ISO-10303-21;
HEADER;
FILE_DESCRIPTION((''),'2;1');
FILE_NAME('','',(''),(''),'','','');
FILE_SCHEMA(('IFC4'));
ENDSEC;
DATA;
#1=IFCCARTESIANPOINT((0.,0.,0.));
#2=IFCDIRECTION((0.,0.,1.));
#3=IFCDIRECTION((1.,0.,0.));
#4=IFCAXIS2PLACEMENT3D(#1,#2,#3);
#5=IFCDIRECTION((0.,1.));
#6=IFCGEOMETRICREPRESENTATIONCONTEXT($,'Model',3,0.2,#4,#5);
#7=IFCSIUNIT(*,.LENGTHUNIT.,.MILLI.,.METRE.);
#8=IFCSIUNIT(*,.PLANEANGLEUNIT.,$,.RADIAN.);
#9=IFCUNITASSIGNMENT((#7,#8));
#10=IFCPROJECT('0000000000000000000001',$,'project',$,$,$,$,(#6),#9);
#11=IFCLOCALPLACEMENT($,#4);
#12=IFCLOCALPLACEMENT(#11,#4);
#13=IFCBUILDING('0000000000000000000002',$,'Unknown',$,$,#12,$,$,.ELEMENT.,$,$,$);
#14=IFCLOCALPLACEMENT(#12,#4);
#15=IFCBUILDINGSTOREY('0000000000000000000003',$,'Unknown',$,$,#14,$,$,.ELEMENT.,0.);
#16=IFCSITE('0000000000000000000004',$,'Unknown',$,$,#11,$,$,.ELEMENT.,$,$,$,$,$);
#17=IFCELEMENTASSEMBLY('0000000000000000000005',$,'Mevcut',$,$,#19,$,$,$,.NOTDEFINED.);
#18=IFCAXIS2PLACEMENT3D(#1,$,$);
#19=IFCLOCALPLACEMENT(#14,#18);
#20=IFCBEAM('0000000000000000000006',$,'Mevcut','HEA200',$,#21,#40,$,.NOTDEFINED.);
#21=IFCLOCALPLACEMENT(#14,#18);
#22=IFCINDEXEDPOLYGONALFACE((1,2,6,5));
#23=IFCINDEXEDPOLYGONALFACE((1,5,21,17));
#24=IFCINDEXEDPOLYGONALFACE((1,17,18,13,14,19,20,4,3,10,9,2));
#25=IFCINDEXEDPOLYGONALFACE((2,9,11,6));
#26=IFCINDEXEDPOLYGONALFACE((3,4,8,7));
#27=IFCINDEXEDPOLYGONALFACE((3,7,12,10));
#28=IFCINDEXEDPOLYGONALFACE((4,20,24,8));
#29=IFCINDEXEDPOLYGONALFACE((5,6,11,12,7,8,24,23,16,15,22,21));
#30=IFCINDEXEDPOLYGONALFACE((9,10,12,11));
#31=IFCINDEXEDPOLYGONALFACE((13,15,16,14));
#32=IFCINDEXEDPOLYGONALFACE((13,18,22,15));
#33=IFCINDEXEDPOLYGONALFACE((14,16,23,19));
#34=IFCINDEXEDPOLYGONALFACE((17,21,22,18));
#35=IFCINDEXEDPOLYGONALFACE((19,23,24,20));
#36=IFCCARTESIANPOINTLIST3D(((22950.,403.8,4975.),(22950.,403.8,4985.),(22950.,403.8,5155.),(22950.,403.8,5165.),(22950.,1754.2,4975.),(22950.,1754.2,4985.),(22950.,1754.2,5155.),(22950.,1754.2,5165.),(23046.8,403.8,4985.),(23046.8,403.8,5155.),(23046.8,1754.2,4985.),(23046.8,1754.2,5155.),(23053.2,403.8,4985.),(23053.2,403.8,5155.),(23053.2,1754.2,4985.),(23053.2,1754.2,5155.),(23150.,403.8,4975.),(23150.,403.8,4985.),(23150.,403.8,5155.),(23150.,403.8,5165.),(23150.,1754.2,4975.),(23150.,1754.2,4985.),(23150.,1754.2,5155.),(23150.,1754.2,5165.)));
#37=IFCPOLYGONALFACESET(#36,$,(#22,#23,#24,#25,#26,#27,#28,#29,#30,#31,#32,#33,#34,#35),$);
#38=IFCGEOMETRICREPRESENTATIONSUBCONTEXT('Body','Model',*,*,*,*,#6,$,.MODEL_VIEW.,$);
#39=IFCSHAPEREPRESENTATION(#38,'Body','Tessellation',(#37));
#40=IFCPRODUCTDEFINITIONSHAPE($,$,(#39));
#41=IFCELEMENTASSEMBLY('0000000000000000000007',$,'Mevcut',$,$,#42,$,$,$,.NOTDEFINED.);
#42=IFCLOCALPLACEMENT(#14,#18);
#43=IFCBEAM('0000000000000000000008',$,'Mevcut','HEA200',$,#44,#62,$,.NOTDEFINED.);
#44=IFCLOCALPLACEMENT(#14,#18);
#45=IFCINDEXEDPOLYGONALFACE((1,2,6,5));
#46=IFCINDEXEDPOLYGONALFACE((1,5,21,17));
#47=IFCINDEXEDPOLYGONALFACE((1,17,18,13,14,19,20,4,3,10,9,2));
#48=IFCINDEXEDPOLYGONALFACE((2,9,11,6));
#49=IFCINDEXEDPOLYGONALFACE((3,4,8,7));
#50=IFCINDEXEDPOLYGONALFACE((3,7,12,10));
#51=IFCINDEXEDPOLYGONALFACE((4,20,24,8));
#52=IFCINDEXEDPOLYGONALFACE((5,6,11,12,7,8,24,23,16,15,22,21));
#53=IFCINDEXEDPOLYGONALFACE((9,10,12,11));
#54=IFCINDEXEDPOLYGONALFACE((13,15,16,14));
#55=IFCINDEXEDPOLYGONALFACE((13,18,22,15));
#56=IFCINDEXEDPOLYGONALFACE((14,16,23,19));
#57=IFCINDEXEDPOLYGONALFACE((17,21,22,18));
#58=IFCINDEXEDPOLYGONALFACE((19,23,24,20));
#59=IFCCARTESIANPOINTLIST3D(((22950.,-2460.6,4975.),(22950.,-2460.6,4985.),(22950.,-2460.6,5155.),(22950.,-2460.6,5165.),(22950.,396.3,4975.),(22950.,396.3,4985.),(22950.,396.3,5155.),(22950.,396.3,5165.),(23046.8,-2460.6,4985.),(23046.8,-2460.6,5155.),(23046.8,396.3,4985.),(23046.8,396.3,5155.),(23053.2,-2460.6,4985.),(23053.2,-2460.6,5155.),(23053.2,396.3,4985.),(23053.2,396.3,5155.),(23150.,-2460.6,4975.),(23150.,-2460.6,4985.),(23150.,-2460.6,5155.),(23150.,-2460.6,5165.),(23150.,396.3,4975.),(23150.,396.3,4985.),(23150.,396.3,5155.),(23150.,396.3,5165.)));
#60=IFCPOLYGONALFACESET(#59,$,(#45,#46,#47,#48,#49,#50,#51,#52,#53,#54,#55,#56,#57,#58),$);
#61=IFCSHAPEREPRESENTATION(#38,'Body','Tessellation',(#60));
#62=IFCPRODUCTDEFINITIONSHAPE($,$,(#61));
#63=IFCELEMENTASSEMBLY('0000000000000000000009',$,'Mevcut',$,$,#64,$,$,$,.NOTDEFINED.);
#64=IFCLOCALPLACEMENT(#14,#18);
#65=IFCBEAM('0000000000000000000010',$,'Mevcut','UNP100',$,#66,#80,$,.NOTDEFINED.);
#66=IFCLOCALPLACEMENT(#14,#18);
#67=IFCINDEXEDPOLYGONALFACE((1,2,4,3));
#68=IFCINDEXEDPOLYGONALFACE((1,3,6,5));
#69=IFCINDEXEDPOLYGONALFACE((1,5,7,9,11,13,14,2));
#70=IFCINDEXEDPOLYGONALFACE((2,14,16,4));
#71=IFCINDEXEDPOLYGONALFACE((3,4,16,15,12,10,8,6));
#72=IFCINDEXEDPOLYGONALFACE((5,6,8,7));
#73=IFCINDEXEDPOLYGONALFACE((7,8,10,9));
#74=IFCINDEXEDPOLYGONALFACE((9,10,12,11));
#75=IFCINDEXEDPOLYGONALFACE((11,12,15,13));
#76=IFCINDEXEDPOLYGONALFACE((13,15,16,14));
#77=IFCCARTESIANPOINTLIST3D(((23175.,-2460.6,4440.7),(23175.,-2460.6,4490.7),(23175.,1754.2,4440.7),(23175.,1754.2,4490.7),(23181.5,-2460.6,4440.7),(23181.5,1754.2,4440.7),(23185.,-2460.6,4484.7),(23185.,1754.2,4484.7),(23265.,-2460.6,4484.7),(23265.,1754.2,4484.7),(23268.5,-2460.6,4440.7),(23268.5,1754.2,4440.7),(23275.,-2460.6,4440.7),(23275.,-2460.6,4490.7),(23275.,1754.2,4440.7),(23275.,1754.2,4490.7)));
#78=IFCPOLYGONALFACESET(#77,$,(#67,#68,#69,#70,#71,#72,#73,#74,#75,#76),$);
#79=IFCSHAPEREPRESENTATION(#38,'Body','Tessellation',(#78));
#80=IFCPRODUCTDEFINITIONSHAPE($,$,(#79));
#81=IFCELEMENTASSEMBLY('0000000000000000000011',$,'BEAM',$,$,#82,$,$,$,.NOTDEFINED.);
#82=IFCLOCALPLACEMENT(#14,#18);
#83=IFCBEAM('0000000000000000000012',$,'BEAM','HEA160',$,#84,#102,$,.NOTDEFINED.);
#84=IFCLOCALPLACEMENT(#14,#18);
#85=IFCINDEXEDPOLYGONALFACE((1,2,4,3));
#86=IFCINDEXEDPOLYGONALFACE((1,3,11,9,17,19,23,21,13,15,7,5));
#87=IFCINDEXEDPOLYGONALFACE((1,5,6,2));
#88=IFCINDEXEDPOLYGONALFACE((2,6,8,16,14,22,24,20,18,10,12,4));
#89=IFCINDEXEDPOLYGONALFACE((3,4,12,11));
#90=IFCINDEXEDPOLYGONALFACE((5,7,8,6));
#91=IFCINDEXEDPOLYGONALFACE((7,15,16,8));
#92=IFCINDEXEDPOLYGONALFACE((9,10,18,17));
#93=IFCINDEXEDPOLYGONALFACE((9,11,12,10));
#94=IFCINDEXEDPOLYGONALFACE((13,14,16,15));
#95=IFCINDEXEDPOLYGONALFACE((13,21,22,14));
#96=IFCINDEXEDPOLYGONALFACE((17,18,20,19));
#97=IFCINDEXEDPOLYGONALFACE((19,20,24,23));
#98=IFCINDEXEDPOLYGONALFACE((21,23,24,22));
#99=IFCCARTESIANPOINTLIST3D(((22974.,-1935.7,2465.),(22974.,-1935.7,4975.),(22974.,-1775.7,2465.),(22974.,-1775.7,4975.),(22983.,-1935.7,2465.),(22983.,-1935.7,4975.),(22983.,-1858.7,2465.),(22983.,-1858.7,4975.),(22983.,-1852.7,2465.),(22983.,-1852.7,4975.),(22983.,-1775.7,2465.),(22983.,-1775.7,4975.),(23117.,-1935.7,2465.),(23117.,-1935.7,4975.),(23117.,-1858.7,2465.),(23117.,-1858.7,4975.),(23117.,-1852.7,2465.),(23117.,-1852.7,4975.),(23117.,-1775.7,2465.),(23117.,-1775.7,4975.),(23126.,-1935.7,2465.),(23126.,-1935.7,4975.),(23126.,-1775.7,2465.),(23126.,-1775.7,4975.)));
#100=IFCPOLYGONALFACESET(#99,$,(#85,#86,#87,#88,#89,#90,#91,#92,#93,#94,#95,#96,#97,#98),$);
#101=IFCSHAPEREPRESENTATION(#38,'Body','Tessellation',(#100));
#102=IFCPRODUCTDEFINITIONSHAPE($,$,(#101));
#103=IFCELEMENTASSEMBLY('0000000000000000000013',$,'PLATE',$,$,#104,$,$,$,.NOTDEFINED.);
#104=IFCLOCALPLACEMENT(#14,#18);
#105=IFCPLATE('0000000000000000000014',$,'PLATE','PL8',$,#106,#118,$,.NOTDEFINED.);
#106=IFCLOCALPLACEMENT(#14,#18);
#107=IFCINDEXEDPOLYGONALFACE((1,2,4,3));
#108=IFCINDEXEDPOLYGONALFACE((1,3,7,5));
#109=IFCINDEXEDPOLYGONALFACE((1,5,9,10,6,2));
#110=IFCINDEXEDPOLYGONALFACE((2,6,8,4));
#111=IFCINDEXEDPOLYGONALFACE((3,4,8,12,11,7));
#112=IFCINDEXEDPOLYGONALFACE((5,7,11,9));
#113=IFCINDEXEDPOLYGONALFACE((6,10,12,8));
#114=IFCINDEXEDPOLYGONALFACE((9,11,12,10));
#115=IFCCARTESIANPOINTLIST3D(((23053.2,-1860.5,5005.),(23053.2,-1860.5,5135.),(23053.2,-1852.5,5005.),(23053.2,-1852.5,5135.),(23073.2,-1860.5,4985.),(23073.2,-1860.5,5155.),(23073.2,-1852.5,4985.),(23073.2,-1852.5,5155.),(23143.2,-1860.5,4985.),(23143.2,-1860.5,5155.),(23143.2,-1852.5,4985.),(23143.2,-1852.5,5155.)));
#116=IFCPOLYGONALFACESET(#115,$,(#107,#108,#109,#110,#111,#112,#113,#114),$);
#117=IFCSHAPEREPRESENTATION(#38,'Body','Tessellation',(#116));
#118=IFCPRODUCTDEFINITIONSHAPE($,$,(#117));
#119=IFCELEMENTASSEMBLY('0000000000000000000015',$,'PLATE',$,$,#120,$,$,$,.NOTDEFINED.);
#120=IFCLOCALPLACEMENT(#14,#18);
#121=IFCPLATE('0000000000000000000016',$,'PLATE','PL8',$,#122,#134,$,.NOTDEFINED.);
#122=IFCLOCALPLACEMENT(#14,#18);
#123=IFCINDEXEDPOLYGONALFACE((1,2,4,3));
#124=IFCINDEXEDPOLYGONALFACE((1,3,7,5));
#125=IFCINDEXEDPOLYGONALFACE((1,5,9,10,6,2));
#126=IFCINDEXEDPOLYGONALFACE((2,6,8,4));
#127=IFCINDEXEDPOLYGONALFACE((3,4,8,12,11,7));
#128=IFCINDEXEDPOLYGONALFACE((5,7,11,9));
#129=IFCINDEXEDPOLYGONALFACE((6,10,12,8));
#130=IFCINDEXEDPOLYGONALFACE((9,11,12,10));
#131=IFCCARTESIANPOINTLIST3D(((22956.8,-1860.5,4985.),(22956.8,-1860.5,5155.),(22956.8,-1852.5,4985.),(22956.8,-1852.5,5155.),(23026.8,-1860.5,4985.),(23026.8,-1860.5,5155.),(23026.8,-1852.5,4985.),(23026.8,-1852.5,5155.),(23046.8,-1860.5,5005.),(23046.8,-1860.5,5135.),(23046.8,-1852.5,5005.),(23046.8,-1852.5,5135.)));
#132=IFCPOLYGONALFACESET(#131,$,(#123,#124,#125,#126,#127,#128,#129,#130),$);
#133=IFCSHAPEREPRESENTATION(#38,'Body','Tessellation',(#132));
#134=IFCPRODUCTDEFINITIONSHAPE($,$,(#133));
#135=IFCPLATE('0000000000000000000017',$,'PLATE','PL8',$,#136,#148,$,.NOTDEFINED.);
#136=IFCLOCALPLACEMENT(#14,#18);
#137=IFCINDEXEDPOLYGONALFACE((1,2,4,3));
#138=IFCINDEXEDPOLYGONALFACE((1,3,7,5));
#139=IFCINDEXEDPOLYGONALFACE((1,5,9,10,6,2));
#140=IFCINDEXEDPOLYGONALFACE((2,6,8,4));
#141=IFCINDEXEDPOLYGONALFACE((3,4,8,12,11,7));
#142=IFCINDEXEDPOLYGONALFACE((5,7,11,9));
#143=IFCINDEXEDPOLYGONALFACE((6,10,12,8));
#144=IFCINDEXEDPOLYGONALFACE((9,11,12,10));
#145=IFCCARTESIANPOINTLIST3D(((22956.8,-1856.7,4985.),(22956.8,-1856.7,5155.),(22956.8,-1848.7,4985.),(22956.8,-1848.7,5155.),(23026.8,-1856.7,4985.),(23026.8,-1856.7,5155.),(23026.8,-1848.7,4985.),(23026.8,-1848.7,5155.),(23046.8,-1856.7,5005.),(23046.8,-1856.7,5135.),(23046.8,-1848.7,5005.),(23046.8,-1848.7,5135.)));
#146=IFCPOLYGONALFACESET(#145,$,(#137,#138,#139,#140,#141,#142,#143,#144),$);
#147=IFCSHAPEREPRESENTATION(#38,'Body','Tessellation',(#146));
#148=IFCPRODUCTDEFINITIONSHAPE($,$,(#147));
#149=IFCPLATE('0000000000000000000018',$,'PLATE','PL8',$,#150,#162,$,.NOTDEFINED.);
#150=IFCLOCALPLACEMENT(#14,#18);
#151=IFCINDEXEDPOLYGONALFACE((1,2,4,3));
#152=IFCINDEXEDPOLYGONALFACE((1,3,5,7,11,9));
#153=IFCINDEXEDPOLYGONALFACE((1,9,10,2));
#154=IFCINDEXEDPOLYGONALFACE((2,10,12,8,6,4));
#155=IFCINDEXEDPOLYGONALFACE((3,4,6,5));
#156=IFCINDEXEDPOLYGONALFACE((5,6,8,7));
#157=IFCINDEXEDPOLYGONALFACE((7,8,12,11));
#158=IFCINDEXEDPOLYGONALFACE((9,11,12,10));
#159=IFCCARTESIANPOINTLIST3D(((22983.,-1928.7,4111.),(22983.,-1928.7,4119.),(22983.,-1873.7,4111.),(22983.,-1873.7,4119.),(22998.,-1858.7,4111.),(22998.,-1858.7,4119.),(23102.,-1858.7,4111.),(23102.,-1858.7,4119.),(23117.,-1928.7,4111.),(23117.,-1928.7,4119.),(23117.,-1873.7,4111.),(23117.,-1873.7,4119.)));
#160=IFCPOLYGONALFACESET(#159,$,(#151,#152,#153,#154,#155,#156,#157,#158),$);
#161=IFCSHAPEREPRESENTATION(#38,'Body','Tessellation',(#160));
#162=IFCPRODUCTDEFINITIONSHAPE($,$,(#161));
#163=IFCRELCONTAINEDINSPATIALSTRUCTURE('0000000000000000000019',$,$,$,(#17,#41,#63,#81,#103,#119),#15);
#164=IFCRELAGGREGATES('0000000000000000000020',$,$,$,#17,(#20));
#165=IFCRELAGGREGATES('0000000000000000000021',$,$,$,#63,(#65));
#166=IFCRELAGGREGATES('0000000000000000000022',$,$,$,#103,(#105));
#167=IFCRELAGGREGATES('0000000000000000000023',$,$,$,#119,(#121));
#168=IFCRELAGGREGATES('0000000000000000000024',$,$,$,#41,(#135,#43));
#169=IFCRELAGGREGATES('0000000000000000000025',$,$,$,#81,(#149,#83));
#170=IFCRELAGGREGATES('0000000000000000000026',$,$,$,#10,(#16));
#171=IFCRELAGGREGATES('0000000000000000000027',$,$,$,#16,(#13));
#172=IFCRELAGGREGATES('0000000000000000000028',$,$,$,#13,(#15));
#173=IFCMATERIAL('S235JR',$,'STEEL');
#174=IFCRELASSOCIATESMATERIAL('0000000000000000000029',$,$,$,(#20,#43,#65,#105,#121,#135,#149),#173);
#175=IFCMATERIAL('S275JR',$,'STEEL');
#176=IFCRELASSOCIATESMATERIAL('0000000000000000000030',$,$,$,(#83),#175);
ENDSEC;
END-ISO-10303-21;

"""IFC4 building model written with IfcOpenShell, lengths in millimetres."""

from ifc_helpers import new_model, si_unit, direction, frame, origin_with_axes, place, context, subcontext, project, spatial, line, indexed_curve, outline, extrude, material, element, aggregate, save


model = new_model("IFC4")

# Units and contexts
model_context = context("Model", 3, precision=0.2, world=origin_with_axes(), true_north=direction((0.0, 1.0)))
body_context = subcontext(model_context, "Body", "Model", "MODEL_VIEW")
ifc_project = project(units=[si_unit("LENGTHUNIT", "METRE", prefix="MILLI"), si_unit("PLANEANGLEUNIT", "RADIAN")], contexts=[model_context])

# Site, building, storey
site_placement = place(None, origin_with_axes())
site = spatial("IfcSite", under=ifc_project, at=site_placement, Name="Unknown", CompositionType="ELEMENT")
building_placement = place(site_placement, origin_with_axes())
building = spatial("IfcBuilding", under=site, at=building_placement, Name="Unknown", CompositionType="ELEMENT")
storey_placement = place(building_placement, origin_with_axes())
storey = spatial("IfcBuildingStorey", under=building, at=storey_placement, Name="Unknown", CompositionType="ELEMENT", Elevation=0.0)

# Element assemblies, beams
assembly_1_placement = place(storey_placement, frame((23050.0, 1754.2, 5070.0), z_axis=(-1.0, 0.0, 0.0), x_axis=(0.0, -1.0, 0.0)))
assembly_1 = element("IfcElementAssembly", 1, at=assembly_1_placement, inside=storey, Name="Mevcut", PredefinedType="NOTDEFINED")
ifc_material_1 = material(Name="S235JR", Category="STEEL")
beam_1_placement = place(assembly_1_placement, origin_with_axes())
beam_1 = element("IfcBeam", 2, at=beam_1_placement, material=ifc_material_1, Name="Mevcut", Description="HEA200", PredefinedType="NOTDEFINED", context=body_context, shape_type="SolidModel", body=[
    extrude(outline(indexed_curve([(-100.0, -95.0), (100.0, -95.0), (100.0, -85.0), (3.2, -85.0), (3.2, 85.0), (100.0, 85.0), (100.0, 95.0), (-100.0, 95.0), (-100.0, 85.0), (-3.2, 85.0), (-3.2, -85.0), (-100.0, -85.0)], segments=[line(1, 2, 3, 4, 5, 6, 7, 8, 9, 10, 11, 12, 1)])), frame((0.0, 0.0, 0.0), z_axis=(-1.0, 0.0, 0.0), x_axis=(0.0, 0.0, 1.0)), (0.0, 0.0, -1.0), 1350.4),
])
aggregate(assembly_1, [beam_1])
assembly_2_placement = place(storey_placement, frame((23050.0, 396.3, 5070.0), z_axis=(-1.0, 0.0, 0.0), x_axis=(0.0, -1.0, 0.0)))
assembly_2 = element("IfcElementAssembly", 3, at=assembly_2_placement, inside=storey, Name="Mevcut", PredefinedType="NOTDEFINED")
beam_2_placement = place(assembly_2_placement, origin_with_axes())
beam_2 = element("IfcBeam", 4, at=beam_2_placement, material=ifc_material_1, Name="Mevcut", Description="HEA200", PredefinedType="NOTDEFINED", context=body_context, shape_type="SolidModel", body=[
    extrude(outline(indexed_curve([(-100.0, -95.0), (100.0, -95.0), (100.0, -85.0), (3.2, -85.0), (3.2, 85.0), (100.0, 85.0), (100.0, 95.0), (-100.0, 95.0), (-100.0, 85.0), (-3.2, 85.0), (-3.2, -85.0), (-100.0, -85.0)], segments=[line(1, 2, 3, 4, 5, 6, 7, 8, 9, 10, 11, 12, 1)])), frame((0.0, 0.0, 0.0), z_axis=(-1.0, 0.0, 0.0), x_axis=(0.0, 0.0, 1.0)), (0.0, 0.0, -1.0), 2856.9),
])
assembly_3_placement = place(storey_placement, frame((23225.0, 1754.2, 4465.7), z_axis=(0.0, 0.0, -1.0), x_axis=(0.0, -1.0, 0.0)))
assembly_3 = element("IfcElementAssembly", 5, at=assembly_3_placement, inside=storey, Name="Mevcut", PredefinedType="NOTDEFINED")
beam_3_placement = place(assembly_3_placement, origin_with_axes())
beam_3 = element("IfcBeam", 6, at=beam_3_placement, material=ifc_material_1, Name="Mevcut", Description="UNP100", PredefinedType="NOTDEFINED", context=body_context, shape_type="SolidModel", body=[
    extrude(outline(indexed_curve([(-25.0, -50.0), (25.0, -50.0), (25.0, -43.5), (-19.0, -40.0), (-19.0, 40.0), (25.0, 43.5), (25.0, 50.0), (-25.0, 50.0)], segments=[line(1, 2, 3, 4, 5, 6, 7, 8, 1)])), frame((0.0, 0.0, 0.0), z_axis=(-1.0, 0.0, 0.0), x_axis=(0.0, 0.0, 1.0)), (0.0, 0.0, -1.0), 4214.9),
])
aggregate(assembly_3, [beam_3])
assembly_4_placement = place(storey_placement, frame((23050.0, -1855.7, 4975.0), z_axis=(0.0, -1.0, 0.0), x_axis=(0.0, 0.0, -1.0)))
assembly_4 = element("IfcElementAssembly", 7, at=assembly_4_placement, inside=storey, Name="BEAM", PredefinedType="NOTDEFINED")
ifc_material_2 = material(Name="S275JR", Category="STEEL")
beam_4_placement = place(assembly_4_placement, origin_with_axes())
beam_4 = element("IfcBeam", 8, at=beam_4_placement, material=ifc_material_2, Name="BEAM", Description="HEA160", PredefinedType="NOTDEFINED", context=body_context, shape_type="SolidModel", body=[
    extrude(outline(indexed_curve([(-80.0, -76.0), (80.0, -76.0), (80.0, -67.0), (3.0, -67.0), (3.0, 67.0), (80.0, 67.0), (80.0, 76.0), (-80.0, 76.0), (-80.0, 67.0), (-3.0, 67.0), (-3.0, -67.0), (-80.0, -67.0)], segments=[line(1, 2, 3, 4, 5, 6, 7, 8, 9, 10, 11, 12, 1)])), frame((0.0, 0.0, 0.0), z_axis=(-1.0, 0.0, 0.0), x_axis=(0.0, 0.0, 1.0)), (0.0, 0.0, -1.0), 2510.0),
])

# Element assemblies, plates
assembly_5_placement = place(storey_placement, frame((23053.2, -1856.5, 4985.0), z_axis=(0.0, -1.0, 0.0), x_axis=(1.0, 0.0, 0.0)))
assembly_5 = element("IfcElementAssembly", 9, at=assembly_5_placement, inside=storey, Name="PLATE", PredefinedType="NOTDEFINED")
plate_1_placement = place(assembly_5_placement, origin_with_axes())
plate_1 = element("IfcPlate", 10, at=plate_1_placement, material=ifc_material_1, Name="PLATE", Description="PL8", PredefinedType="NOTDEFINED", context=body_context, shape_type="SolidModel", body=[
    extrude(outline(indexed_curve([(0.0, 20.0), (20.0, 0.0), (90.0, 0.0), (90.0, 170.0), (20.0, 170.0), (0.0, 150.0)], segments=[line(1, 2, 3, 4, 5, 6, 1)])), frame((0.0, 0.0, 4.0), z_axis=(0.0, 0.0, 1.0), x_axis=(1.0, 0.0, 0.0)), (0.0, 0.0, -1.0), 8.0),
])
aggregate(assembly_5, [plate_1])
assembly_6_placement = place(storey_placement, frame((23046.8, -1856.5, 4985.0), z_axis=(0.0, 1.0, 0.0), x_axis=(-1.0, 0.0, 0.0)))
assembly_6 = element("IfcElementAssembly", 11, at=assembly_6_placement, inside=storey, Name="PLATE", PredefinedType="NOTDEFINED")
plate_2_placement = place(assembly_6_placement, origin_with_axes())
plate_2 = element("IfcPlate", 12, at=plate_2_placement, material=ifc_material_1, Name="PLATE", Description="PL8", PredefinedType="NOTDEFINED", context=body_context, shape_type="SolidModel", body=[
    extrude(outline(indexed_curve([(0.0, 20.0), (20.0, 0.0), (90.0, 0.0), (90.0, 170.0), (20.0, 170.0), (0.0, 150.0)], segments=[line(1, 2, 3, 4, 5, 6, 1)])), frame((0.0, 0.0, 4.0), z_axis=(0.0, 0.0, 1.0), x_axis=(1.0, 0.0, 0.0)), (0.0, 0.0, -1.0), 8.0),
])
aggregate(assembly_6, [plate_2])

# Plate
plate_3_placement = place(assembly_2_placement, frame((2249.0, -85.0, 3.2), z_axis=(-1.0, 0.0, 0.0), x_axis=(0.0, 0.0, 1.0)))
plate_3 = element("IfcPlate", 13, at=plate_3_placement, material=ifc_material_1, Name="PLATE", Description="PL8", PredefinedType="NOTDEFINED", context=body_context, shape_type="SolidModel", body=[
    extrude(outline(indexed_curve([(0.0, 20.0), (20.0, 0.0), (90.0, 0.0), (90.0, 170.0), (20.0, 170.0), (0.0, 150.0)], segments=[line(1, 2, 3, 4, 5, 6, 1)])), frame((0.0, 0.0, 4.0), z_axis=(0.0, 0.0, 1.0), x_axis=(1.0, 0.0, 0.0)), (0.0, 0.0, -1.0), 8.0),
])
aggregate(assembly_2, [plate_3, beam_2])

# Plate
plate_4_placement = place(assembly_4_placement, frame((860.0, -67.0, 3.0), z_axis=(-1.0, 0.0, 0.0), x_axis=(0.0, 0.0, 1.0)))
plate_4 = element("IfcPlate", 14, at=plate_4_placement, material=ifc_material_1, Name="PLATE", Description="PL8", PredefinedType="NOTDEFINED", context=body_context, shape_type="SolidModel", body=[
    extrude(outline(indexed_curve([(0.0, 15.0), (15.0, 0.0), (70.0, 0.0), (70.0, 134.0), (15.0, 134.0), (0.0, 119.0)], segments=[line(1, 2, 3, 4, 5, 6, 1)])), frame((0.0, 0.0, 4.0), z_axis=(0.0, 0.0, 1.0), x_axis=(1.0, 0.0, 0.0)), (0.0, 0.0, -1.0), 8.0),
])
aggregate(assembly_4, [plate_4, beam_4])

save(model, "model.ifc")
